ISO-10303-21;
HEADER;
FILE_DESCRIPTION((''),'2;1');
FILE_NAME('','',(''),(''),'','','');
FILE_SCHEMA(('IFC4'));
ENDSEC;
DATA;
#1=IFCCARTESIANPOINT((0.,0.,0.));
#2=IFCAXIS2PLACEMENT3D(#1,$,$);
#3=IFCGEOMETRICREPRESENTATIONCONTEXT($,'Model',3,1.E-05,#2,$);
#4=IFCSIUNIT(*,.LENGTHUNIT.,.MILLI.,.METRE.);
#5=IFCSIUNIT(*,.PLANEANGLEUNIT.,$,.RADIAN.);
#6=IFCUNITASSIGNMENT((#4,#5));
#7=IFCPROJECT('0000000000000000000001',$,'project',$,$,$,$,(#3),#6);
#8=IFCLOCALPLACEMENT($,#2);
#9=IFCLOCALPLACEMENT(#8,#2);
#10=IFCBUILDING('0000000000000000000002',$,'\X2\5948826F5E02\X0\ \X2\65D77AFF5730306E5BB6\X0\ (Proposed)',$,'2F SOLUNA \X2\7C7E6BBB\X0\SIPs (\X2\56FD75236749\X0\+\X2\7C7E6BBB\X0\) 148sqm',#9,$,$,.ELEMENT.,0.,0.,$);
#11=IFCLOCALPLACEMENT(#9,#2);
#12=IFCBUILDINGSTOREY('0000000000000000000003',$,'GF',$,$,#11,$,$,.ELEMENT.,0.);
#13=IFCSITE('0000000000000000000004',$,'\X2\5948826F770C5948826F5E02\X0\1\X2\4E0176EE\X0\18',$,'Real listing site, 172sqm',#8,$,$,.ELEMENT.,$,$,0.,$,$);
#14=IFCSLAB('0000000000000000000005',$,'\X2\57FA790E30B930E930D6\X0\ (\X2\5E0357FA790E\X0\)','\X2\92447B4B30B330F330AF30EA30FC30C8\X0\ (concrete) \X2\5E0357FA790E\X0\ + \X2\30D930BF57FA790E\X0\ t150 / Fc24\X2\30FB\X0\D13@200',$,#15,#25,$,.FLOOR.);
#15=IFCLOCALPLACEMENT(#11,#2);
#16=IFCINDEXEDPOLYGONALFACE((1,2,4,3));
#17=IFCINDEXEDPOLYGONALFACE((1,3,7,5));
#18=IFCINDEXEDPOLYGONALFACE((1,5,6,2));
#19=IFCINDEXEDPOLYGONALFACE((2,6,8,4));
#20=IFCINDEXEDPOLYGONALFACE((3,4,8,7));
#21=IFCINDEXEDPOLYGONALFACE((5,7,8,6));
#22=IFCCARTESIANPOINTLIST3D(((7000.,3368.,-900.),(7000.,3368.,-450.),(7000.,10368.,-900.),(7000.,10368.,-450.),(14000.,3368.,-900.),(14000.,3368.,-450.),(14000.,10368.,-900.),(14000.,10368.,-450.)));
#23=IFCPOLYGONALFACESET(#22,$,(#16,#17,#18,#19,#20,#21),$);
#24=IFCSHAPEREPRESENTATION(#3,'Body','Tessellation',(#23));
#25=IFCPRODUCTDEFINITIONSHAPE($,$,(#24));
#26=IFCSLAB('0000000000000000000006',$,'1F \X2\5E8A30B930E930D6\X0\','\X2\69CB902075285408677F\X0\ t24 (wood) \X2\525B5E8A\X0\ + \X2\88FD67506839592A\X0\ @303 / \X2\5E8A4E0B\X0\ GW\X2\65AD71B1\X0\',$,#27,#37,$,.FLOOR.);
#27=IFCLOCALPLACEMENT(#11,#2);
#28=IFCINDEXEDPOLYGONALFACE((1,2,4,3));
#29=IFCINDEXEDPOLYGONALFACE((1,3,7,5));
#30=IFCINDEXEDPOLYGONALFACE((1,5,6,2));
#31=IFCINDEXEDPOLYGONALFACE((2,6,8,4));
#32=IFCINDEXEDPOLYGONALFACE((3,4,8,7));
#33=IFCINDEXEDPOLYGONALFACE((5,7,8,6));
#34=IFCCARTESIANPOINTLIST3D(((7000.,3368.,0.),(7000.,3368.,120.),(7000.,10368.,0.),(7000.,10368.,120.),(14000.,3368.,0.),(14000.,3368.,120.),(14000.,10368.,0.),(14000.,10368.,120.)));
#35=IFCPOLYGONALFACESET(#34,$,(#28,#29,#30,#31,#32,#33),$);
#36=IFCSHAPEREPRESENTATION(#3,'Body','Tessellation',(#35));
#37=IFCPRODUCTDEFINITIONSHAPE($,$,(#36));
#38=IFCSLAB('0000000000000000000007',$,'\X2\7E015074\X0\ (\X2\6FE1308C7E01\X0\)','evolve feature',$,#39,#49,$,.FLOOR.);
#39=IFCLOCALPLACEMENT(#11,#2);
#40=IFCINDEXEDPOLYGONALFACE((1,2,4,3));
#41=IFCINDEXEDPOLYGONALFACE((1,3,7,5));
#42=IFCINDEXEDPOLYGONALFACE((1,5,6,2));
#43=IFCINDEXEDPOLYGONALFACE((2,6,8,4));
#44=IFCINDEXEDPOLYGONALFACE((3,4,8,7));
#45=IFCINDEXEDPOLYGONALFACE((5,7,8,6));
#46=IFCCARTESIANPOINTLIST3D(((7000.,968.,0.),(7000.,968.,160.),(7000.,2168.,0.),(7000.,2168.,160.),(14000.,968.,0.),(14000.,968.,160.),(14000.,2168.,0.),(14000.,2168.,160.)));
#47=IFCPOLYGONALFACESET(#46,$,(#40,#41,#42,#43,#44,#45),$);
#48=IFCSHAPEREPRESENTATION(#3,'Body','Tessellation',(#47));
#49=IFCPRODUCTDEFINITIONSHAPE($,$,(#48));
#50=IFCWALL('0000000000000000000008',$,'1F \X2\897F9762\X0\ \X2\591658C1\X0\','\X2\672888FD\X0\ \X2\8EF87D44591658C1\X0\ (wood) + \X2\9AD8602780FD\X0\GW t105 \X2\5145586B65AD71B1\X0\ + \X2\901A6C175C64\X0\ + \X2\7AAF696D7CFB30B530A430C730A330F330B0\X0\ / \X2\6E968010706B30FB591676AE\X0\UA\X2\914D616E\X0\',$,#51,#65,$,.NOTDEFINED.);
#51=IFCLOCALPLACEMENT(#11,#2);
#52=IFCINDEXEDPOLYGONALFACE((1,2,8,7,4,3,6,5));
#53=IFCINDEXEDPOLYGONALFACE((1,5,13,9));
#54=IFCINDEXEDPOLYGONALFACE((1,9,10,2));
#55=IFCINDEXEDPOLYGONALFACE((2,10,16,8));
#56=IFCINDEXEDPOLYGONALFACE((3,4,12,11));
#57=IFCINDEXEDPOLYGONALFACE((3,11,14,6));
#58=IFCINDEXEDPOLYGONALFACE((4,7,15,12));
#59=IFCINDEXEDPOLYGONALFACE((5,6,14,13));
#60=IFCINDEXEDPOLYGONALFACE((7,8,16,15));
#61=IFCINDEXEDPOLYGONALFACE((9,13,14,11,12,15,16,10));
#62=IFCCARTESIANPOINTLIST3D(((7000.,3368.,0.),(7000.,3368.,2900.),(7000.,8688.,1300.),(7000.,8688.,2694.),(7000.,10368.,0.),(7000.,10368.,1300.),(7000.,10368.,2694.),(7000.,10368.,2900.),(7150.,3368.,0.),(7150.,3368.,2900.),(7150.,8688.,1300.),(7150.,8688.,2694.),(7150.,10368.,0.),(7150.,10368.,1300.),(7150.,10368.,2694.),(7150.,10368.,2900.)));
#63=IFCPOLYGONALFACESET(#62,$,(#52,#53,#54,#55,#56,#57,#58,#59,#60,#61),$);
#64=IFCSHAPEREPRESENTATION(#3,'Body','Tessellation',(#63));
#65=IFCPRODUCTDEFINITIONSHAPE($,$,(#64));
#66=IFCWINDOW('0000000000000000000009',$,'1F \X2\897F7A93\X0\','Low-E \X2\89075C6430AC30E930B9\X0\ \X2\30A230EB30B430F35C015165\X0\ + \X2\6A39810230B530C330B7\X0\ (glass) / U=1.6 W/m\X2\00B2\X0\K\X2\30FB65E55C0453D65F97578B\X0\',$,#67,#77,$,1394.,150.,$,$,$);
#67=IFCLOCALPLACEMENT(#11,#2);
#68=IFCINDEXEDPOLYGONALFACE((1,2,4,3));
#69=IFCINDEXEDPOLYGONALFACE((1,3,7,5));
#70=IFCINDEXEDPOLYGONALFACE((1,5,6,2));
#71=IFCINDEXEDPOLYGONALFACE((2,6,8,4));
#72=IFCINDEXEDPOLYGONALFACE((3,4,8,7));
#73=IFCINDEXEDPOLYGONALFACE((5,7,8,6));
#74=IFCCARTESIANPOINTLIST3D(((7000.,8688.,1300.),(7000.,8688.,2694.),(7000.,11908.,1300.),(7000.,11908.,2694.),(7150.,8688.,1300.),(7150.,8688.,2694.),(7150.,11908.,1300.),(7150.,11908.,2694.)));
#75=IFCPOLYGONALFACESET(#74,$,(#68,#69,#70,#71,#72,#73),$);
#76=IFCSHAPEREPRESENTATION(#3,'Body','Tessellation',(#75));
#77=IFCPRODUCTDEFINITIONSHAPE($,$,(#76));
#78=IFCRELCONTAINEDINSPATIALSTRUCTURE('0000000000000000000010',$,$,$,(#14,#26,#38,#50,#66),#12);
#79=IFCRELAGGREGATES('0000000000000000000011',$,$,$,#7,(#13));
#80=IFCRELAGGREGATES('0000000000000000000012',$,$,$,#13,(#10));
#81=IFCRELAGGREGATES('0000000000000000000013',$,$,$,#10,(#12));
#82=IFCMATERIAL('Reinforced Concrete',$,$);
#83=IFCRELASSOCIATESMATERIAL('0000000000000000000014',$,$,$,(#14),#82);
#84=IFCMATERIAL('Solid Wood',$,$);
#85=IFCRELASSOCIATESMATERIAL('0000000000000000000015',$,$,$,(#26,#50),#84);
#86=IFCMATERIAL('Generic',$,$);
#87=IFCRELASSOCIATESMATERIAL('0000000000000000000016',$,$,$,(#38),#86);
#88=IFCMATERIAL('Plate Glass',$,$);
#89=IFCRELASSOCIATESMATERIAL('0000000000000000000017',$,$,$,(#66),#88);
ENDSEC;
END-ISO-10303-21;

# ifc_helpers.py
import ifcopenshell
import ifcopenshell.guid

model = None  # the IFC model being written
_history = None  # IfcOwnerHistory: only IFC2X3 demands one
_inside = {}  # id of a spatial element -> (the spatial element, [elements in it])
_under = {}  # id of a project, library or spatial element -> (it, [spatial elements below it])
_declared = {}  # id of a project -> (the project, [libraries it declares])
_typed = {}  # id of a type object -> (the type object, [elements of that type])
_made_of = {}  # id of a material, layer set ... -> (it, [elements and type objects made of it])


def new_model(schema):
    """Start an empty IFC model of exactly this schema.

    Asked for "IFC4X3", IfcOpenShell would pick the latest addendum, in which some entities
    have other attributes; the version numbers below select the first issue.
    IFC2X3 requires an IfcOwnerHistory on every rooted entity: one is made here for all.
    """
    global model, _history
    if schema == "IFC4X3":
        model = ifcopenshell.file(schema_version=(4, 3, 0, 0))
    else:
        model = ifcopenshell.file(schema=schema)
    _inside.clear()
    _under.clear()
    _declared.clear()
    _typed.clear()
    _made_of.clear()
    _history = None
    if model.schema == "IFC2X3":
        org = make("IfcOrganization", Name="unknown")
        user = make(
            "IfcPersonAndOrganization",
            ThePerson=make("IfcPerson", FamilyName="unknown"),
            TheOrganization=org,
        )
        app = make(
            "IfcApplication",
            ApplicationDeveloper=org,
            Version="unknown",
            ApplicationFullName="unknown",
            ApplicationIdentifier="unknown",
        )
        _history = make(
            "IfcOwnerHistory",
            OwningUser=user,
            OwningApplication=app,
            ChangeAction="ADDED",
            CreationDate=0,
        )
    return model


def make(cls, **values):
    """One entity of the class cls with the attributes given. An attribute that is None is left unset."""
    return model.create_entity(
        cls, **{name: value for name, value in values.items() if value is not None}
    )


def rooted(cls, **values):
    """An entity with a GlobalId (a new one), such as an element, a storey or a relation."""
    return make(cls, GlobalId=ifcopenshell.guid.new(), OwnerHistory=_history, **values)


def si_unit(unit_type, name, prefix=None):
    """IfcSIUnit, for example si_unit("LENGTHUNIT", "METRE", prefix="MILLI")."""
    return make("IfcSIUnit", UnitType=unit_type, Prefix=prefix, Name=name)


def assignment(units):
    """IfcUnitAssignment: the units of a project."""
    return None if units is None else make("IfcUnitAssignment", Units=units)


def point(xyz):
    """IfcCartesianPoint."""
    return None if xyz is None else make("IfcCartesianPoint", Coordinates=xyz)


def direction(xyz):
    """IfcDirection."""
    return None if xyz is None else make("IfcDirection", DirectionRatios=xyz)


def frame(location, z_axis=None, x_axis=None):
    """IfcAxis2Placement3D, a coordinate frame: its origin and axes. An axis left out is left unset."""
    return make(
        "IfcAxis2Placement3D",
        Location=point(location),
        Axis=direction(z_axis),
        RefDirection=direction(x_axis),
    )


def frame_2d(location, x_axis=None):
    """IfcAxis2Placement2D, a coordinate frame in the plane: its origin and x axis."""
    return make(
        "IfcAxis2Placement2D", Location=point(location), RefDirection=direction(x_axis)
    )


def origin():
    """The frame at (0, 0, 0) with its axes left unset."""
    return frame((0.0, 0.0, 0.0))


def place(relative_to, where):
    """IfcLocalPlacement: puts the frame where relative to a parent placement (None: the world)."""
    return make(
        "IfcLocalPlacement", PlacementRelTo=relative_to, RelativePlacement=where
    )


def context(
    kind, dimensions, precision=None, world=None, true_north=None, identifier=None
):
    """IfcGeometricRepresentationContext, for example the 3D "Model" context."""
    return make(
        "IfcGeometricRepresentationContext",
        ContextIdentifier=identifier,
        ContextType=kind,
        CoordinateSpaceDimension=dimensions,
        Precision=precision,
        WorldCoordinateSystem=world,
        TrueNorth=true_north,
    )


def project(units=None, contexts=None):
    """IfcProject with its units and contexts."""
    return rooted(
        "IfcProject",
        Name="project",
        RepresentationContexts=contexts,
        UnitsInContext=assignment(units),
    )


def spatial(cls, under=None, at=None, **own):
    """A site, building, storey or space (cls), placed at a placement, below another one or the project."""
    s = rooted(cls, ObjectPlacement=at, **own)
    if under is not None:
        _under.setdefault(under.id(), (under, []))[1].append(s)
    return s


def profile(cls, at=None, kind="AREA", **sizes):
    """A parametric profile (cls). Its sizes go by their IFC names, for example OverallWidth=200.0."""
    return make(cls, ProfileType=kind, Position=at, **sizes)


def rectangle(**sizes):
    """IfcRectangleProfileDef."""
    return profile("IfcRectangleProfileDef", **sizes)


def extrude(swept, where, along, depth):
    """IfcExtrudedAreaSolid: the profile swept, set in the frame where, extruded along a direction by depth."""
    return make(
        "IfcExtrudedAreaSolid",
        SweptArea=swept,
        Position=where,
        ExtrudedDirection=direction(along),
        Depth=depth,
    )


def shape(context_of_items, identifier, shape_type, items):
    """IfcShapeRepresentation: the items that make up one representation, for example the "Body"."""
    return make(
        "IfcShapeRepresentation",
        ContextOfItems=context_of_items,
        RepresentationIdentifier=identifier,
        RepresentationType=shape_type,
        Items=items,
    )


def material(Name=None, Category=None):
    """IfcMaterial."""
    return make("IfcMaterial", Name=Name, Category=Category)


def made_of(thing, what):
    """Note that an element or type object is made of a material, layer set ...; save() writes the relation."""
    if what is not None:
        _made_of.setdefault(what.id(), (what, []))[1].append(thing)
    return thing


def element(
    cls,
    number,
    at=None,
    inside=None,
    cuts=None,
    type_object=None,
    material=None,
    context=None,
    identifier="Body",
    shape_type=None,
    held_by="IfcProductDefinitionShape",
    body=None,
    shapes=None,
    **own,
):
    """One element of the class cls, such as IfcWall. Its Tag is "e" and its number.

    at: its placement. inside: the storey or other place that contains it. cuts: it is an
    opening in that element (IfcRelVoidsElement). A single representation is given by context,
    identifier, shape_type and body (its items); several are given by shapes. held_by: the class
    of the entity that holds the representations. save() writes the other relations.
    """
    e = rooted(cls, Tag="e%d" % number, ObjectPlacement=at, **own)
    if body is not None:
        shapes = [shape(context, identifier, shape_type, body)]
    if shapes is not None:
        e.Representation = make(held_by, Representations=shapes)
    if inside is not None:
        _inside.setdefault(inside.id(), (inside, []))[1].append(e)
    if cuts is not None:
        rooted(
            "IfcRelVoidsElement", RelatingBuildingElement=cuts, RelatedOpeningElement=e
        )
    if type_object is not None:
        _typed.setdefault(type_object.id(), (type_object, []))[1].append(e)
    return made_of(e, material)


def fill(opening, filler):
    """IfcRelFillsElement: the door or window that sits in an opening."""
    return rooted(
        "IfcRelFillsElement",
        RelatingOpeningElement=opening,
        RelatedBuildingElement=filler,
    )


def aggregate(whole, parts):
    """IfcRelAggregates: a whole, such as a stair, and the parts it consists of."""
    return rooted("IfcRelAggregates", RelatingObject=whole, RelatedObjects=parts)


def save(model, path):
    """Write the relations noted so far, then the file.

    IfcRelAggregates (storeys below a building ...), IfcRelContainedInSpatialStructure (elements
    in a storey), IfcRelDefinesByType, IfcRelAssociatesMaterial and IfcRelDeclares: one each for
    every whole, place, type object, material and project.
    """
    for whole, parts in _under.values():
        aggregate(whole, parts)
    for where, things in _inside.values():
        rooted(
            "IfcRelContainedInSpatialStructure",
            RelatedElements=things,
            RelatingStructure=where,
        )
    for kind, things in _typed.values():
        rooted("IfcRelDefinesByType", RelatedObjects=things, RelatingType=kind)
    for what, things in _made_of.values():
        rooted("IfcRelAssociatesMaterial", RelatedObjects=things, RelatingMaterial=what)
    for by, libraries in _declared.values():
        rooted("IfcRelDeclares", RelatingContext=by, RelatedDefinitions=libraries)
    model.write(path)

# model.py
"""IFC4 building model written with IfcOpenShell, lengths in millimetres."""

from ifc_helpers import new_model, si_unit, frame, frame_2d, origin, place, context, project, spatial, rectangle, extrude, material, element, fill, save


model = new_model("IFC4")

# Units and contexts
model_context = context("Model", 3, precision=1e-05, world=origin())
ifc_project = project(units=[si_unit("LENGTHUNIT", "METRE", prefix="MILLI"), si_unit("PLANEANGLEUNIT", "RADIAN")], contexts=[model_context])

# Site, building, storey
site_placement = place(None, origin())
site = spatial("IfcSite", under=ifc_project, at=site_placement, Name="奈良県奈良市1丁目18", ObjectType="Real listing site, 172sqm", CompositionType="ELEMENT", RefElevation=0.0)
building_placement = place(site_placement, origin())
building = spatial("IfcBuilding", under=site, at=building_placement, Name="奈良市 旗竿地の家 (Proposed)", ObjectType="2F SOLUNA 籾殻SIPs (国産杉+籾殻) 148sqm", CompositionType="ELEMENT", ElevationOfRefHeight=0.0, ElevationOfTerrain=0.0)
storey_placement = place(building_placement, origin())
storey = spatial("IfcBuildingStorey", under=building, at=storey_placement, Name="GF", CompositionType="ELEMENT", Elevation=0.0)

# Slabs
ifc_material_1 = material(Name="Reinforced Concrete")
slab_1_placement = place(storey_placement, frame((3500.0, 1684.0, -450.0)))
element("IfcSlab", 1, at=slab_1_placement, inside=storey, material=ifc_material_1, Name="基礎スラブ (布基礎)", Description="鉄筋コンクリート (concrete) 布基礎 + ベタ基礎 t150 / Fc24・D13@200", PredefinedType="FLOOR", context=model_context, shape_type="SweptSolid", body=[
    extrude(rectangle(XDim=7000.0, YDim=7000.0, at=frame_2d((3500.0, 3500.0))), frame((3500.0, 1684.0, -450.0)), (0.0, 0.0, 1.0), 450.0),
])
ifc_material_2 = material(Name="Solid Wood")
slab_2_placement = place(storey_placement, frame((3500.0, 1684.0, 0.0)))
element("IfcSlab", 2, at=slab_2_placement, inside=storey, material=ifc_material_2, Name="1F 床スラブ", Description="構造用合板 t24 (wood) 剛床 + 製材根太 @303 / 床下 GW断熱", PredefinedType="FLOOR", context=model_context, shape_type="SweptSolid", body=[
    extrude(rectangle(XDim=7000.0, YDim=7000.0, at=frame_2d((3500.0, 3500.0))), frame((3500.0, 1684.0, 0.0)), (0.0, 0.0, 1.0), 120.0),
])
ifc_material_3 = material(Name="Generic")
slab_3_placement = place(storey_placement, frame((3500.0, 484.0, 0.0)))
element("IfcSlab", 3, at=slab_3_placement, inside=storey, material=ifc_material_3, Name="縁側 (濡れ縁)", Description="evolve feature", PredefinedType="FLOOR", context=model_context, shape_type="SweptSolid", body=[
    extrude(rectangle(XDim=7000.0, YDim=1200.0, at=frame_2d((3500.0, 600.0))), frame((3500.0, 484.0, 0.0)), (0.0, 0.0, 1.0), 160.0),
])

# Shared definitions
ifc_material_4 = material(Name="Plate Glass")

# Wall, opening, window
wall_1_placement = place(storey_placement, frame((3500.0, 1684.0, 0.0)))
wall_1 = element("IfcWall", 4, at=wall_1_placement, inside=storey, material=ifc_material_2, Name="1F 西面 外壁", Description="木製 軸組外壁 (wood) + 高性能GW t105 充填断熱 + 通気層 + 窯業系サイディング / 準耐火・外皮UA配慮", PredefinedType="NOTDEFINED", context=model_context, shape_type="SweptSolid", body=[
    extrude(rectangle(XDim=150.0, YDim=7000.0, at=frame_2d((75.0, 3500.0))), frame((3500.0, 1684.0, 0.0)), (0.0, 0.0, 1.0), 2900.0),
])
opening_1_placement = place(storey_placement, frame((3500.0, 4344.0, 650.0)))
opening_1 = element("IfcOpeningElement", 5, at=opening_1_placement, cuts=wall_1, PredefinedType="NOTDEFINED", context=model_context, shape_type="SweptSolid", body=[
    extrude(rectangle(XDim=150.0, YDim=3220.0, at=frame_2d((75.0, 1610.0))), frame((3500.0, 4344.0, 650.0)), (0.0, 0.0, 1.0), 1394.0),
])
window_1_placement = place(storey_placement, frame((3500.0, 4344.0, 650.0)))
window_1 = element("IfcWindow", 6, at=window_1_placement, inside=storey, material=ifc_material_4, Name="1F 西窓", Description="Low-E 複層ガラス アルゴン封入 + 樹脂サッシ (glass) / U=1.6 W/m²K・日射取得型", OverallHeight=1394.0, OverallWidth=150.0, context=model_context, shape_type="SweptSolid", body=[
    extrude(rectangle(XDim=150.0, YDim=3220.0, at=frame_2d((75.0, 1610.0))), frame((3500.0, 4344.0, 650.0)), (0.0, 0.0, 1.0), 1394.0),
])
fill(opening_1, window_1)

save(model, "model.ifc")
